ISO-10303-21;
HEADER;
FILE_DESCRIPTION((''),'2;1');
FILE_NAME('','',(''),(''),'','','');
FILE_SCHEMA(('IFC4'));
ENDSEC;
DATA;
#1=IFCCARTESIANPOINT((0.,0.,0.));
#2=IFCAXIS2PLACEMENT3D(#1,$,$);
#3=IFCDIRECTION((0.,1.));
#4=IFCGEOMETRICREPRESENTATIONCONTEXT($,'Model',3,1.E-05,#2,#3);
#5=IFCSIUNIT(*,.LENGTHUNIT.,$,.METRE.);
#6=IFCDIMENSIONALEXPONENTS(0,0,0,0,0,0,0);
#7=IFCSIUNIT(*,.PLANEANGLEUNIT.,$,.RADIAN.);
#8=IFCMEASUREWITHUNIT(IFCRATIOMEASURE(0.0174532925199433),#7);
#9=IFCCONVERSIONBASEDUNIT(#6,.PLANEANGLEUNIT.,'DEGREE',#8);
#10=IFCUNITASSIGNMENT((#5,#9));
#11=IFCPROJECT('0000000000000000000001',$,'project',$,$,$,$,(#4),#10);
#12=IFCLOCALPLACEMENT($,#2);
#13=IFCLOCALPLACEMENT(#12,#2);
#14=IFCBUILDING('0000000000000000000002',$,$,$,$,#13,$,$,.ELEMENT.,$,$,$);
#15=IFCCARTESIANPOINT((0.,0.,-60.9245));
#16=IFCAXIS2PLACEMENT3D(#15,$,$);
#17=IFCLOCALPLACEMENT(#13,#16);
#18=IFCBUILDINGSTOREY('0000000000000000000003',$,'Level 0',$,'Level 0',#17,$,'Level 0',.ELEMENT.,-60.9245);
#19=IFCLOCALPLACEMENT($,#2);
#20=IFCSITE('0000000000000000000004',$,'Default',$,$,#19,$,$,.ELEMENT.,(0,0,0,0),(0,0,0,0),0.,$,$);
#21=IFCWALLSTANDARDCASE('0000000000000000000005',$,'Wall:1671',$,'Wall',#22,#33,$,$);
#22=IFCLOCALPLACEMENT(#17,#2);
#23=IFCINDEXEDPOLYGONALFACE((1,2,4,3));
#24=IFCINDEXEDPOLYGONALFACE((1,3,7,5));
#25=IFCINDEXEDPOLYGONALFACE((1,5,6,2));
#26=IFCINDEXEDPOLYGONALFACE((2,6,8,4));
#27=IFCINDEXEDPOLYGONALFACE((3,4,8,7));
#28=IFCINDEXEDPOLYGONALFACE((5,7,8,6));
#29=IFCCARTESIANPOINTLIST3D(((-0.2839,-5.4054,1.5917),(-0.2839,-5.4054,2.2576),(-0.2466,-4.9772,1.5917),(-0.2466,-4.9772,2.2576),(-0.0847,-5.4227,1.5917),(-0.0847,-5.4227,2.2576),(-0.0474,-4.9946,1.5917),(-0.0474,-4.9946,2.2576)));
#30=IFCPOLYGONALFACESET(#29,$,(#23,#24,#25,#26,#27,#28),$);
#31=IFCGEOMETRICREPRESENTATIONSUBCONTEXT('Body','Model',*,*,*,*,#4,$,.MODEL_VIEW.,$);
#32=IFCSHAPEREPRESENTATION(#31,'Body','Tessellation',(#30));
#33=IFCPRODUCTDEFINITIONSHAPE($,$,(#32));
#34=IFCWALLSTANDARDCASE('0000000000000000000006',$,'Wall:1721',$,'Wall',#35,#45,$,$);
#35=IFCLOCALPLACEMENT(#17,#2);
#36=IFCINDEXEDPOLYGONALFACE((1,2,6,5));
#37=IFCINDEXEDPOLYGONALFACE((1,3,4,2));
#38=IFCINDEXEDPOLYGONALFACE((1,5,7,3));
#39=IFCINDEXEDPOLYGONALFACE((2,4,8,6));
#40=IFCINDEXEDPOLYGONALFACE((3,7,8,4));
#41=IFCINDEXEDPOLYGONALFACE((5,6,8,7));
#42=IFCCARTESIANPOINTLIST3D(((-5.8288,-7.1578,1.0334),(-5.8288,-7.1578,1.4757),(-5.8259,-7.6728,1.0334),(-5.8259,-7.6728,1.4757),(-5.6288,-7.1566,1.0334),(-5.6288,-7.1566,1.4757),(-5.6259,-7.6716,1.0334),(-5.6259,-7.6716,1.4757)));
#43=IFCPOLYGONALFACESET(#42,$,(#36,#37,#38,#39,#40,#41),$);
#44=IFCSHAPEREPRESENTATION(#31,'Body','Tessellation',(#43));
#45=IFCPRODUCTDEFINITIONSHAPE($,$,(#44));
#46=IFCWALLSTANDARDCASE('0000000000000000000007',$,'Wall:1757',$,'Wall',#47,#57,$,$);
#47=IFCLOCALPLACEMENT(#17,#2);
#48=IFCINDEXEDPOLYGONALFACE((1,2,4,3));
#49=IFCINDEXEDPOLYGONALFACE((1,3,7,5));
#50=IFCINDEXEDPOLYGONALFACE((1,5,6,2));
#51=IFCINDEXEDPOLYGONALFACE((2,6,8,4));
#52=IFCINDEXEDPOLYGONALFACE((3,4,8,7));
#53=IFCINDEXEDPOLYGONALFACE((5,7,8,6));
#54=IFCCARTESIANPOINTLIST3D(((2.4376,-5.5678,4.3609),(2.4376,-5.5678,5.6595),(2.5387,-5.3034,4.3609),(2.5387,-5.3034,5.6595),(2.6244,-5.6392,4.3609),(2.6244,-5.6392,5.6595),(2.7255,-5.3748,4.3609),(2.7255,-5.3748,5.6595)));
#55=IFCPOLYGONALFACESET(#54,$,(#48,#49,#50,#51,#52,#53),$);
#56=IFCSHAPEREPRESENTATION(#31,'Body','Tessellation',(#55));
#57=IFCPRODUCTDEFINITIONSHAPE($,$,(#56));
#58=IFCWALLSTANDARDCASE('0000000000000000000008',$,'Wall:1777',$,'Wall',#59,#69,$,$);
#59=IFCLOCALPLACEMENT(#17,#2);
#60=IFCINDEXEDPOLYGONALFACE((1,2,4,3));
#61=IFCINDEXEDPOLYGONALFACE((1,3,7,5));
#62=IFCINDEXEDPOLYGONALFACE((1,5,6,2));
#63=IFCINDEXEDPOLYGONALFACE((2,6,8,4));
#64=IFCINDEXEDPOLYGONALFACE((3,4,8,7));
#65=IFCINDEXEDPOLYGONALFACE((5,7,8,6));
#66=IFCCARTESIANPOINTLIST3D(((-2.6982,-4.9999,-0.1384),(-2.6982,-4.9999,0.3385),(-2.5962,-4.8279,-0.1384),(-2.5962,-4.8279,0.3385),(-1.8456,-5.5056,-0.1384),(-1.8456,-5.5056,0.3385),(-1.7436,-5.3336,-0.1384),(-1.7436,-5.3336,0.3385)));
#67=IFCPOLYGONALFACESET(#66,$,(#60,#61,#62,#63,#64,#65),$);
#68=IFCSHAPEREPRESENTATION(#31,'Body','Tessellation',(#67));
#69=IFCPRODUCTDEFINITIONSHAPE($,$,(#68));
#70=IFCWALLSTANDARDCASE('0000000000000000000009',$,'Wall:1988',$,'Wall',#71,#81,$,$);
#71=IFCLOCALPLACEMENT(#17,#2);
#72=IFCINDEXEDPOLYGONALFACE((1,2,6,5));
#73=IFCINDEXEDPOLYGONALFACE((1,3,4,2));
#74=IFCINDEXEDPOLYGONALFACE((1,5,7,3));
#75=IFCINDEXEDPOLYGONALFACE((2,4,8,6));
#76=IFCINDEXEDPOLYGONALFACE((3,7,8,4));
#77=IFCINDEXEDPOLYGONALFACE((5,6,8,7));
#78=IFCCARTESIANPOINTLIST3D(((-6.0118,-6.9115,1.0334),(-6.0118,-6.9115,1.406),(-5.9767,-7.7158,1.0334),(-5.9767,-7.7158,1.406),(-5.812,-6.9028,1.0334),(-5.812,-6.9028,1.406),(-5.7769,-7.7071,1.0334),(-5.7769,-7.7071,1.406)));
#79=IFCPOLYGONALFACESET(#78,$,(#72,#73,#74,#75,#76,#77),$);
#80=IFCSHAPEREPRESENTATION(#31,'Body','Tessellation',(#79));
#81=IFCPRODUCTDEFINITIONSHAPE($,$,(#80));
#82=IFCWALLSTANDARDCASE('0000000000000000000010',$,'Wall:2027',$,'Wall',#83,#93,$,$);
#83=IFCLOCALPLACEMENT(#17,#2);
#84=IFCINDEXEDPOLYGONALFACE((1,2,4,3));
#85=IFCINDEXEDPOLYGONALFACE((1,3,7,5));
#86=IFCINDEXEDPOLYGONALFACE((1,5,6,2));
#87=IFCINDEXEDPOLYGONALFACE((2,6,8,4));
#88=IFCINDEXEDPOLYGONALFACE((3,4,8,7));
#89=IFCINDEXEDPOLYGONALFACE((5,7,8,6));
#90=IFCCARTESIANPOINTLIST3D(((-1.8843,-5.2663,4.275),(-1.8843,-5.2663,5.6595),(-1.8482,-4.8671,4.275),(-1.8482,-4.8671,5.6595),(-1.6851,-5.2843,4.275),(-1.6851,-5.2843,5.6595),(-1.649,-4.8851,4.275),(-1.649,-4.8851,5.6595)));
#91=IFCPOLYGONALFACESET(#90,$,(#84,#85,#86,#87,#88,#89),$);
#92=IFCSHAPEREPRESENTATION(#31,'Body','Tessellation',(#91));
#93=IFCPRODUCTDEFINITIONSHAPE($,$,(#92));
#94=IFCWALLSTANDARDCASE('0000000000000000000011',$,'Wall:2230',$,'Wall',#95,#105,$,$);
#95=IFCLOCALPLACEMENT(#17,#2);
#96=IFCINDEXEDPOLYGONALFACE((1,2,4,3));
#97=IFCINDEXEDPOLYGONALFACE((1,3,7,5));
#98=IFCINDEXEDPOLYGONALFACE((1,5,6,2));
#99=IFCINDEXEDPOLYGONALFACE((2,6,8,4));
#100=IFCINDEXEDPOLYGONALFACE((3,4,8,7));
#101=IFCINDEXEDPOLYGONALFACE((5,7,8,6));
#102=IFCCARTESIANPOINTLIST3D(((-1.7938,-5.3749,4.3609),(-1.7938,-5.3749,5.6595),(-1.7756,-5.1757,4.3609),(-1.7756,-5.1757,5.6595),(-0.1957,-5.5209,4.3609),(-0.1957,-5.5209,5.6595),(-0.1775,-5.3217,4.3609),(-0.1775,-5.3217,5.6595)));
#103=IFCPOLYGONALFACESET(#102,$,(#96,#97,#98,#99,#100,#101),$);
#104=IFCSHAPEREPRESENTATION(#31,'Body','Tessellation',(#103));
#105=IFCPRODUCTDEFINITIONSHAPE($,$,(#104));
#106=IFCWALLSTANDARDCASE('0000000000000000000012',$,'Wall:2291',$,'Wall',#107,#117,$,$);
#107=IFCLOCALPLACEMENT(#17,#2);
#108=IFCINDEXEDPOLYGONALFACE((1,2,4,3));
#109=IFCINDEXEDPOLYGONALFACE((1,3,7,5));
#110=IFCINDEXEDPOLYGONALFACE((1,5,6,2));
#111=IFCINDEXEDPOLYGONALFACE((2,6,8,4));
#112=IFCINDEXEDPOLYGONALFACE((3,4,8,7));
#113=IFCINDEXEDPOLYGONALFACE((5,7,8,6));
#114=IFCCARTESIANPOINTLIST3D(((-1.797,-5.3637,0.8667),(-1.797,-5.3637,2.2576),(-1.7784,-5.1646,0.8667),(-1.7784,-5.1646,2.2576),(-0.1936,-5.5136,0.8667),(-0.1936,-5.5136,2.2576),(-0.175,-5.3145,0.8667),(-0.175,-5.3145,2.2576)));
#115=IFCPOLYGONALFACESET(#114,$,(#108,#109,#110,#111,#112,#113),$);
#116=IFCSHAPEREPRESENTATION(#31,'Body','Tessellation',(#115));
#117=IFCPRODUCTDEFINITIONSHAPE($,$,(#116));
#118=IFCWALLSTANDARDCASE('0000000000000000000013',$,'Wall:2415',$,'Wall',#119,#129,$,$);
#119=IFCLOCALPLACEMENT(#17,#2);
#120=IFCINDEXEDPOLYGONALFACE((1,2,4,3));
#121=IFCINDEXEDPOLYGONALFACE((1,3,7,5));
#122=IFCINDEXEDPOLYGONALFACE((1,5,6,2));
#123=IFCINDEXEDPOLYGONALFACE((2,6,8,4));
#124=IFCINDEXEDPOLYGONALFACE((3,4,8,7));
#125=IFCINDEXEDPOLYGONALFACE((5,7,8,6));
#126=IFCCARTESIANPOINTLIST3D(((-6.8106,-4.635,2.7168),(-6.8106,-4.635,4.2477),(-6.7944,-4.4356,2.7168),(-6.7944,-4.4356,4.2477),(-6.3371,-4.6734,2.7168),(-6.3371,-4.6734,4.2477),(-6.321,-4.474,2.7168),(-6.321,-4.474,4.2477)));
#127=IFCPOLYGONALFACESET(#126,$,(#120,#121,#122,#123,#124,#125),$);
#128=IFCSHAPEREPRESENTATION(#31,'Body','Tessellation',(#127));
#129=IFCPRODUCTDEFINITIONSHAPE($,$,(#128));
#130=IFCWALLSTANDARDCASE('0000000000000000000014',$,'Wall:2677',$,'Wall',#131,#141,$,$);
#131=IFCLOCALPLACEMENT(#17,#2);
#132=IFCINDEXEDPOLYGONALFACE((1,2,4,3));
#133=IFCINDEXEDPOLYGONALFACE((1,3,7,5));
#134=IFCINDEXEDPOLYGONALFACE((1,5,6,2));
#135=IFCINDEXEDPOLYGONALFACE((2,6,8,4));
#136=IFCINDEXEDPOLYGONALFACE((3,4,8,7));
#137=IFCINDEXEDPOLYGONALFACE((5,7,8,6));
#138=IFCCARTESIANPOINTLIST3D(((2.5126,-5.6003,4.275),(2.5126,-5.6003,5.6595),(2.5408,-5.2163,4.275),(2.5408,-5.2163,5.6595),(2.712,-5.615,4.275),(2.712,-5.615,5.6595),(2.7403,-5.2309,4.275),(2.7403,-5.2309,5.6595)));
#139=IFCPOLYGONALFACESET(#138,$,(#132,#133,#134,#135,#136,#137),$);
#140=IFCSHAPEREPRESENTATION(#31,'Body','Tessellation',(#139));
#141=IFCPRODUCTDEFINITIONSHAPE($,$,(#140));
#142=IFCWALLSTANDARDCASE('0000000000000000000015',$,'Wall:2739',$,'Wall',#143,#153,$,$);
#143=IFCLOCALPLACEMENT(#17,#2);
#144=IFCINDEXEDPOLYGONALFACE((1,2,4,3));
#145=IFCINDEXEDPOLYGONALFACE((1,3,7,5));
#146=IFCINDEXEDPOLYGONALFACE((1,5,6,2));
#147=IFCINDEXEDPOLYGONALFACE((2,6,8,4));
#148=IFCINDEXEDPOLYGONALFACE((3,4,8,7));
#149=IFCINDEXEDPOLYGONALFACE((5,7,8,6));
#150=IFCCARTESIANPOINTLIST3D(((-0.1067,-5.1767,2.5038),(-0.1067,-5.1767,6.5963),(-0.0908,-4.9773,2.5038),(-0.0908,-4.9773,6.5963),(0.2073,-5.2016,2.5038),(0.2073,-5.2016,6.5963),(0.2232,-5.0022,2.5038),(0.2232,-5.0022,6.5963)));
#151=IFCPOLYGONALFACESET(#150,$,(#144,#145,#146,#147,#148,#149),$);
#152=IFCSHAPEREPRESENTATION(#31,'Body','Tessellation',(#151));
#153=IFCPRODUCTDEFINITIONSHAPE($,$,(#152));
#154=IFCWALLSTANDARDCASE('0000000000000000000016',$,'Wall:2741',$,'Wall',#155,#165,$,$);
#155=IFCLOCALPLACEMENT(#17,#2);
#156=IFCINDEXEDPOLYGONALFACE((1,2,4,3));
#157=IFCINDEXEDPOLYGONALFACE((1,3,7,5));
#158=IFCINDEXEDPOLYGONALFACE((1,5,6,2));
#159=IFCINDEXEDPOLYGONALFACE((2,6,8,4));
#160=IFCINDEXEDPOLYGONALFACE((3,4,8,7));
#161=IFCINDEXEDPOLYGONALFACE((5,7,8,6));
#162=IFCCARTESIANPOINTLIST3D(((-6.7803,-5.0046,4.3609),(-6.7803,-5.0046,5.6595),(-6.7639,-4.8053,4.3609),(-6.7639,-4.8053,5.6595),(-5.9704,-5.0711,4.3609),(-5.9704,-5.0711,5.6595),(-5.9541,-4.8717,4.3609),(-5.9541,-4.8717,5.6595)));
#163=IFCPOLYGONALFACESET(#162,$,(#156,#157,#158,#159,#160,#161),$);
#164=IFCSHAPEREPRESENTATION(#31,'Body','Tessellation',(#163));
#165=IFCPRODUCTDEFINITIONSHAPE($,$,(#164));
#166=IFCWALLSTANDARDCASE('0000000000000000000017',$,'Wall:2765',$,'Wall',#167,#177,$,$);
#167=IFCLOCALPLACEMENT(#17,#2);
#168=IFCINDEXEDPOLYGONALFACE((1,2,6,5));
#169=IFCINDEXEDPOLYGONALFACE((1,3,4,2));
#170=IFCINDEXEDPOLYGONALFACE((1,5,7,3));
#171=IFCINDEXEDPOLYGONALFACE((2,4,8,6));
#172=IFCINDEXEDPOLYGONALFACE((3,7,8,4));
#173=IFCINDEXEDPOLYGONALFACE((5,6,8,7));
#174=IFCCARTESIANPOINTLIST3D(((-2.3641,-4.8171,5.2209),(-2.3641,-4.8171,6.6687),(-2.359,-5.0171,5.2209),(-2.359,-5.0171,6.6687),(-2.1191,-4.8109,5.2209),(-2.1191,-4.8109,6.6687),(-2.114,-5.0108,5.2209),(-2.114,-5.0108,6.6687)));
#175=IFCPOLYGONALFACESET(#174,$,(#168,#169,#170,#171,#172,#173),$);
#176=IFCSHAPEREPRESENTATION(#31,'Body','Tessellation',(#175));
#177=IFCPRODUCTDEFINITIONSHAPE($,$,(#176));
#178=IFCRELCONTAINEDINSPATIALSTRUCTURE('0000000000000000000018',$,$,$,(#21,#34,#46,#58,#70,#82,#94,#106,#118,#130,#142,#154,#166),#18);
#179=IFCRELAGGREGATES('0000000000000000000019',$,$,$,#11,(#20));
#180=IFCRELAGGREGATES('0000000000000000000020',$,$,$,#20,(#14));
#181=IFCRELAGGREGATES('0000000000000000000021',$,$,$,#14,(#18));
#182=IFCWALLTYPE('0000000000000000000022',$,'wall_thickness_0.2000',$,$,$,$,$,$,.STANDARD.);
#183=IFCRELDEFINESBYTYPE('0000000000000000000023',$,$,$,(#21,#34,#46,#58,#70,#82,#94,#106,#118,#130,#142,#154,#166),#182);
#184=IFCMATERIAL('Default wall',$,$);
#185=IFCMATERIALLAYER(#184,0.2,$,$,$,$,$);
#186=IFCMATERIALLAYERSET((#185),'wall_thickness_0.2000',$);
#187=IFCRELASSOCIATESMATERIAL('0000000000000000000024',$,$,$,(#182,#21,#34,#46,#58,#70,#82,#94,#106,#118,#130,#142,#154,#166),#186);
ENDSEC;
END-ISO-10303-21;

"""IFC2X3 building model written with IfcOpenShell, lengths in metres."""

from ifc_helpers import new_model, entity, si_unit, converted_unit, direction, frame, origin, place, context, subcontext, project, spatial, polyline, outline, extrude, material, layer, layer_set, layer_usage, type_object, element, save


model = new_model("IFC2X3")

# Units and contexts
model_context = context("Model", 3, precision=1e-05, world=origin(), true_north=direction((0.0, 1.0)))
body_context = subcontext(model_context, "Body", "Model", "MODEL_VIEW")
ifc_project = project(units=[si_unit("LENGTHUNIT", "METRE"), converted_unit("PLANEANGLEUNIT", "DEGREE", entity("IfcRatioMeasure", 0.0174532925199433), si_unit("PLANEANGLEUNIT", "RADIAN"), dimensions=[0, 0, 0, 0, 0, 0, 0])], contexts=[model_context])

# Site, building, storey
site_placement = place(None, origin())
site = spatial("IfcSite", under=ifc_project, at=site_placement, Name="Default", CompositionType="ELEMENT", RefLatitude=(0, 0, 0, 0), RefLongitude=(0, 0, 0, 0), RefElevation=0.0)
placement_1 = place(None, origin())
building_placement = place(placement_1, origin())
building = spatial("IfcBuilding", under=site, at=building_placement, CompositionType="ELEMENT")
storey_placement = place(building_placement, frame((0.0, 0.0, -60.9245)))
storey = spatial("IfcBuildingStorey", under=building, at=storey_placement, Name="Level 0", ObjectType="Level 0", LongName="Level 0", CompositionType="ELEMENT", Elevation=-60.9245)

# Shared definitions
ifc_material_1 = material(Name="Default wall")
ifc_layer = layer(ifc_material_1, 0.2)
ifc_layer_set = layer_set([ifc_layer], Name="wall_thickness_0.2000")
ifc_layer_usage = layer_usage(ifc_layer_set, "AXIS2", "POSITIVE", -0.1)
wall_type = type_object("IfcWallType", Name="wall_thickness_0.2000", PredefinedType="STANDARD", material=ifc_layer_set)

# Walls
placement_2 = place(building_placement, frame((0.0, 0.0, -59.3328)))
wall_1_placement = place(placement_2, frame((-0.147, -4.9859, 0.0), z_axis=(0.0, 0.0, 1.0), x_axis=(-0.086811, -0.996225, 0.0)))
element("IfcWallStandardCase", 1, at=wall_1_placement, inside=storey, type_object=wall_type, material=ifc_layer_usage, Name="Wall:1671", ObjectType="Wall", context=body_context, shape_type="SweptSolid", body=[
    extrude(outline(polyline([(0.4298, -0.1), (0.4298, 0.1), (0.0, 0.1), (0.0, -0.1), (0.4298, -0.1)])), origin(), (0.0, 0.0, 1.0), 0.6659),
])
placement_3 = place(building_placement, frame((0.0, 0.0, -59.8911)))
wall_2_placement = place(placement_3, frame((-5.7288, -7.1572, 0.0), z_axis=(0.0, 0.0, 1.0), x_axis=(0.005629, -0.999984, 0.0)))
element("IfcWallStandardCase", 2, at=wall_2_placement, inside=storey, type_object=wall_type, material=ifc_layer_usage, Name="Wall:1721", ObjectType="Wall", context=body_context, shape_type="SweptSolid", body=[
    extrude(outline(polyline([(0.515, -0.1), (0.515, 0.1), (0.0, 0.1), (0.0, -0.1), (0.515, -0.1)])), origin(), (0.0, 0.0, 1.0), 0.4423),
])
placement_4 = place(building_placement, frame((0.0, 0.0, -56.5636)))
wall_3_placement = place(placement_4, frame((2.6321, -5.3391, 0.0), z_axis=(0.0, 0.0, 1.0), x_axis=(-0.356975, -0.934114, 0.0)))
element("IfcWallStandardCase", 3, at=wall_3_placement, inside=storey, type_object=wall_type, material=ifc_layer_usage, Name="Wall:1757", ObjectType="Wall", context=body_context, shape_type="SweptSolid", body=[
    extrude(outline(polyline([(0.2831, -0.1), (0.2831, 0.1), (0.0, 0.1), (0.0, -0.1), (0.2831, -0.1)])), origin(), (0.0, 0.0, 1.0), 1.2985),
])
placement_5 = place(building_placement, frame((0.0, 0.0, -61.0629)))
wall_4_placement = place(placement_5, frame((-2.6472, -4.9139, 0.0), z_axis=(0.0, 0.0, 1.0), x_axis=(0.860092, -0.51014, 0.0)))
element("IfcWallStandardCase", 4, at=wall_4_placement, inside=storey, type_object=wall_type, material=ifc_layer_usage, Name="Wall:1777", ObjectType="Wall", context=body_context, shape_type="SweptSolid", body=[
    extrude(outline(polyline([(0.9913, -0.1), (0.9913, 0.1), (0.0, 0.1), (0.0, -0.1), (0.9913, -0.1)])), origin(), (0.0, 0.0, 1.0), 0.4769),
])
placement_6 = place(building_placement, frame((0.0, 0.0, -59.8911)))
wall_5_placement = place(placement_6, frame((-5.9119, -6.9072, 0.0), z_axis=(0.0, 0.0, 1.0), x_axis=(0.043537, -0.999052, 0.0)))
element("IfcWallStandardCase", 5, at=wall_5_placement, inside=storey, type_object=wall_type, material=ifc_layer_usage, Name="Wall:1988", ObjectType="Wall", context=body_context, shape_type="SweptSolid", body=[
    extrude(outline(polyline([(0.805, -0.1), (0.805, 0.1), (0.0, 0.1), (0.0, -0.1), (0.805, -0.1)])), origin(), (0.0, 0.0, 1.0), 0.3727),
])
placement_7 = place(building_placement, frame((0.0, 0.0, -56.6495)))
wall_6_placement = place(placement_7, frame((-1.7486, -4.8761, 0.0), z_axis=(0.0, 0.0, 1.0), x_axis=(-0.089918, -0.995949, 0.0)))
element("IfcWallStandardCase", 6, at=wall_6_placement, inside=storey, type_object=wall_type, material=ifc_layer_usage, Name="Wall:2027", ObjectType="Wall", context=body_context, shape_type="SweptSolid", body=[
    extrude(outline(polyline([(0.4009, -0.1), (0.4009, 0.1), (0.0, 0.1), (0.0, -0.1), (0.4009, -0.1)])), origin(), (0.0, 0.0, 1.0), 1.3845),
])
placement_8 = place(building_placement, frame((0.0, 0.0, -56.5636)))
wall_7_placement = place(placement_8, frame((-0.1866, -5.4213, 0.0), z_axis=(0.0, 0.0, 1.0), x_axis=(-0.995854, 0.090965, 0.0)))
element("IfcWallStandardCase", 7, at=wall_7_placement, inside=storey, type_object=wall_type, material=ifc_layer_usage, Name="Wall:2230", ObjectType="Wall", context=body_context, shape_type="SweptSolid", body=[
    extrude(outline(polyline([(1.6047, -0.1), (1.6047, 0.1), (0.0, 0.1), (0.0, -0.1), (1.6047, -0.1)])), origin(), (0.0, 0.0, 1.0), 1.2985),
])
placement_9 = place(building_placement, frame((0.0, 0.0, -60.0578)))
wall_8_placement = place(placement_9, frame((-0.1843, -5.414, 0.0), z_axis=(0.0, 0.0, 1.0), x_axis=(-0.995658, 0.093088, 0.0)))
element("IfcWallStandardCase", 8, at=wall_8_placement, inside=storey, type_object=wall_type, material=ifc_layer_usage, Name="Wall:2291", ObjectType="Wall", context=body_context, shape_type="SweptSolid", body=[
    extrude(outline(polyline([(1.6103, -0.1), (1.6103, 0.1), (0.0, 0.1), (0.0, -0.1), (1.6103, -0.1)])), origin(), (0.0, 0.0, 1.0), 1.3909),
])
placement_10 = place(building_placement, frame((0.0, 0.0, -58.2077)))
wall_9_placement = place(placement_10, frame((-6.3291, -4.5737, 0.0), z_axis=(0.0, 0.0, 1.0), x_axis=(-0.996728, 0.080827, 0.0)))
element("IfcWallStandardCase", 9, at=wall_9_placement, inside=storey, type_object=wall_type, material=ifc_layer_usage, Name="Wall:2415", ObjectType="Wall", context=body_context, shape_type="SweptSolid", body=[
    extrude(outline(polyline([(0.475, -0.1), (0.475, 0.1), (0.0, 0.1), (0.0, -0.1), (0.475, -0.1)])), origin(), (0.0, 0.0, 1.0), 1.5308),
])
placement_11 = place(building_placement, frame((0.0, 0.0, -56.6495)))
wall_10_placement = place(placement_11, frame((2.6123, -5.6077, 0.0), z_axis=(0.0, 0.0, 1.0), x_axis=(0.073414, 0.997302, 0.0)))
element("IfcWallStandardCase", 10, at=wall_10_placement, inside=storey, type_object=wall_type, material=ifc_layer_usage, Name="Wall:2677", ObjectType="Wall", context=body_context, shape_type="SweptSolid", body=[
    extrude(outline(polyline([(0.3851, -0.1), (0.3851, 0.1), (0.0, 0.1), (0.0, -0.1), (0.3851, -0.1)])), origin(), (0.0, 0.0, 1.0), 1.3845),
])
placement_12 = place(building_placement, frame((0.0, 0.0, -58.4207)))
wall_11_placement = place(placement_12, frame((0.2152, -5.1019, 0.0), z_axis=(0.0, 0.0, 1.0), x_axis=(-0.996861, 0.079167, 0.0)))
element("IfcWallStandardCase", 11, at=wall_11_placement, inside=storey, type_object=wall_type, material=ifc_layer_usage, Name="Wall:2739", ObjectType="Wall", context=body_context, shape_type="SweptSolid", body=[
    extrude(outline(polyline([(0.315, -0.1), (0.315, 0.1), (0.0, 0.1), (0.0, -0.1), (0.315, -0.1)])), origin(), (0.0, 0.0, 1.0), 4.0925),
])
placement_13 = place(building_placement, frame((0.0, 0.0, -56.5636)))
wall_12_placement = place(placement_13, frame((-5.9622, -4.9714, 0.0), z_axis=(0.0, 0.0, 1.0), x_axis=(-0.996653, 0.081753, 0.0)))
element("IfcWallStandardCase", 12, at=wall_12_placement, inside=storey, type_object=wall_type, material=ifc_layer_usage, Name="Wall:2741", ObjectType="Wall", context=body_context, shape_type="SweptSolid", body=[
    extrude(outline(polyline([(0.8126, -0.1), (0.8126, 0.1), (0.0, 0.1), (0.0, -0.1), (0.8126, -0.1)])), origin(), (0.0, 0.0, 1.0), 1.2985),
])
placement_14 = place(building_placement, frame((0.0, 0.0, -55.7036)))
wall_13_placement = place(placement_14, frame((-2.1166, -4.9109, 0.0), z_axis=(0.0, 0.0, 1.0), x_axis=(-0.999676, -0.025448, 0.0)))
element("IfcWallStandardCase", 13, at=wall_13_placement, inside=storey, type_object=wall_type, material=ifc_layer_usage, Name="Wall:2765", ObjectType="Wall", context=body_context, shape_type="SweptSolid", body=[
    extrude(outline(polyline([(0.245, -0.1), (0.245, 0.1), (0.0, 0.1), (0.0, -0.1), (0.245, -0.1)])), origin(), (0.0, 0.0, 1.0), 1.4478),
])

save(model, "model.ifc")
